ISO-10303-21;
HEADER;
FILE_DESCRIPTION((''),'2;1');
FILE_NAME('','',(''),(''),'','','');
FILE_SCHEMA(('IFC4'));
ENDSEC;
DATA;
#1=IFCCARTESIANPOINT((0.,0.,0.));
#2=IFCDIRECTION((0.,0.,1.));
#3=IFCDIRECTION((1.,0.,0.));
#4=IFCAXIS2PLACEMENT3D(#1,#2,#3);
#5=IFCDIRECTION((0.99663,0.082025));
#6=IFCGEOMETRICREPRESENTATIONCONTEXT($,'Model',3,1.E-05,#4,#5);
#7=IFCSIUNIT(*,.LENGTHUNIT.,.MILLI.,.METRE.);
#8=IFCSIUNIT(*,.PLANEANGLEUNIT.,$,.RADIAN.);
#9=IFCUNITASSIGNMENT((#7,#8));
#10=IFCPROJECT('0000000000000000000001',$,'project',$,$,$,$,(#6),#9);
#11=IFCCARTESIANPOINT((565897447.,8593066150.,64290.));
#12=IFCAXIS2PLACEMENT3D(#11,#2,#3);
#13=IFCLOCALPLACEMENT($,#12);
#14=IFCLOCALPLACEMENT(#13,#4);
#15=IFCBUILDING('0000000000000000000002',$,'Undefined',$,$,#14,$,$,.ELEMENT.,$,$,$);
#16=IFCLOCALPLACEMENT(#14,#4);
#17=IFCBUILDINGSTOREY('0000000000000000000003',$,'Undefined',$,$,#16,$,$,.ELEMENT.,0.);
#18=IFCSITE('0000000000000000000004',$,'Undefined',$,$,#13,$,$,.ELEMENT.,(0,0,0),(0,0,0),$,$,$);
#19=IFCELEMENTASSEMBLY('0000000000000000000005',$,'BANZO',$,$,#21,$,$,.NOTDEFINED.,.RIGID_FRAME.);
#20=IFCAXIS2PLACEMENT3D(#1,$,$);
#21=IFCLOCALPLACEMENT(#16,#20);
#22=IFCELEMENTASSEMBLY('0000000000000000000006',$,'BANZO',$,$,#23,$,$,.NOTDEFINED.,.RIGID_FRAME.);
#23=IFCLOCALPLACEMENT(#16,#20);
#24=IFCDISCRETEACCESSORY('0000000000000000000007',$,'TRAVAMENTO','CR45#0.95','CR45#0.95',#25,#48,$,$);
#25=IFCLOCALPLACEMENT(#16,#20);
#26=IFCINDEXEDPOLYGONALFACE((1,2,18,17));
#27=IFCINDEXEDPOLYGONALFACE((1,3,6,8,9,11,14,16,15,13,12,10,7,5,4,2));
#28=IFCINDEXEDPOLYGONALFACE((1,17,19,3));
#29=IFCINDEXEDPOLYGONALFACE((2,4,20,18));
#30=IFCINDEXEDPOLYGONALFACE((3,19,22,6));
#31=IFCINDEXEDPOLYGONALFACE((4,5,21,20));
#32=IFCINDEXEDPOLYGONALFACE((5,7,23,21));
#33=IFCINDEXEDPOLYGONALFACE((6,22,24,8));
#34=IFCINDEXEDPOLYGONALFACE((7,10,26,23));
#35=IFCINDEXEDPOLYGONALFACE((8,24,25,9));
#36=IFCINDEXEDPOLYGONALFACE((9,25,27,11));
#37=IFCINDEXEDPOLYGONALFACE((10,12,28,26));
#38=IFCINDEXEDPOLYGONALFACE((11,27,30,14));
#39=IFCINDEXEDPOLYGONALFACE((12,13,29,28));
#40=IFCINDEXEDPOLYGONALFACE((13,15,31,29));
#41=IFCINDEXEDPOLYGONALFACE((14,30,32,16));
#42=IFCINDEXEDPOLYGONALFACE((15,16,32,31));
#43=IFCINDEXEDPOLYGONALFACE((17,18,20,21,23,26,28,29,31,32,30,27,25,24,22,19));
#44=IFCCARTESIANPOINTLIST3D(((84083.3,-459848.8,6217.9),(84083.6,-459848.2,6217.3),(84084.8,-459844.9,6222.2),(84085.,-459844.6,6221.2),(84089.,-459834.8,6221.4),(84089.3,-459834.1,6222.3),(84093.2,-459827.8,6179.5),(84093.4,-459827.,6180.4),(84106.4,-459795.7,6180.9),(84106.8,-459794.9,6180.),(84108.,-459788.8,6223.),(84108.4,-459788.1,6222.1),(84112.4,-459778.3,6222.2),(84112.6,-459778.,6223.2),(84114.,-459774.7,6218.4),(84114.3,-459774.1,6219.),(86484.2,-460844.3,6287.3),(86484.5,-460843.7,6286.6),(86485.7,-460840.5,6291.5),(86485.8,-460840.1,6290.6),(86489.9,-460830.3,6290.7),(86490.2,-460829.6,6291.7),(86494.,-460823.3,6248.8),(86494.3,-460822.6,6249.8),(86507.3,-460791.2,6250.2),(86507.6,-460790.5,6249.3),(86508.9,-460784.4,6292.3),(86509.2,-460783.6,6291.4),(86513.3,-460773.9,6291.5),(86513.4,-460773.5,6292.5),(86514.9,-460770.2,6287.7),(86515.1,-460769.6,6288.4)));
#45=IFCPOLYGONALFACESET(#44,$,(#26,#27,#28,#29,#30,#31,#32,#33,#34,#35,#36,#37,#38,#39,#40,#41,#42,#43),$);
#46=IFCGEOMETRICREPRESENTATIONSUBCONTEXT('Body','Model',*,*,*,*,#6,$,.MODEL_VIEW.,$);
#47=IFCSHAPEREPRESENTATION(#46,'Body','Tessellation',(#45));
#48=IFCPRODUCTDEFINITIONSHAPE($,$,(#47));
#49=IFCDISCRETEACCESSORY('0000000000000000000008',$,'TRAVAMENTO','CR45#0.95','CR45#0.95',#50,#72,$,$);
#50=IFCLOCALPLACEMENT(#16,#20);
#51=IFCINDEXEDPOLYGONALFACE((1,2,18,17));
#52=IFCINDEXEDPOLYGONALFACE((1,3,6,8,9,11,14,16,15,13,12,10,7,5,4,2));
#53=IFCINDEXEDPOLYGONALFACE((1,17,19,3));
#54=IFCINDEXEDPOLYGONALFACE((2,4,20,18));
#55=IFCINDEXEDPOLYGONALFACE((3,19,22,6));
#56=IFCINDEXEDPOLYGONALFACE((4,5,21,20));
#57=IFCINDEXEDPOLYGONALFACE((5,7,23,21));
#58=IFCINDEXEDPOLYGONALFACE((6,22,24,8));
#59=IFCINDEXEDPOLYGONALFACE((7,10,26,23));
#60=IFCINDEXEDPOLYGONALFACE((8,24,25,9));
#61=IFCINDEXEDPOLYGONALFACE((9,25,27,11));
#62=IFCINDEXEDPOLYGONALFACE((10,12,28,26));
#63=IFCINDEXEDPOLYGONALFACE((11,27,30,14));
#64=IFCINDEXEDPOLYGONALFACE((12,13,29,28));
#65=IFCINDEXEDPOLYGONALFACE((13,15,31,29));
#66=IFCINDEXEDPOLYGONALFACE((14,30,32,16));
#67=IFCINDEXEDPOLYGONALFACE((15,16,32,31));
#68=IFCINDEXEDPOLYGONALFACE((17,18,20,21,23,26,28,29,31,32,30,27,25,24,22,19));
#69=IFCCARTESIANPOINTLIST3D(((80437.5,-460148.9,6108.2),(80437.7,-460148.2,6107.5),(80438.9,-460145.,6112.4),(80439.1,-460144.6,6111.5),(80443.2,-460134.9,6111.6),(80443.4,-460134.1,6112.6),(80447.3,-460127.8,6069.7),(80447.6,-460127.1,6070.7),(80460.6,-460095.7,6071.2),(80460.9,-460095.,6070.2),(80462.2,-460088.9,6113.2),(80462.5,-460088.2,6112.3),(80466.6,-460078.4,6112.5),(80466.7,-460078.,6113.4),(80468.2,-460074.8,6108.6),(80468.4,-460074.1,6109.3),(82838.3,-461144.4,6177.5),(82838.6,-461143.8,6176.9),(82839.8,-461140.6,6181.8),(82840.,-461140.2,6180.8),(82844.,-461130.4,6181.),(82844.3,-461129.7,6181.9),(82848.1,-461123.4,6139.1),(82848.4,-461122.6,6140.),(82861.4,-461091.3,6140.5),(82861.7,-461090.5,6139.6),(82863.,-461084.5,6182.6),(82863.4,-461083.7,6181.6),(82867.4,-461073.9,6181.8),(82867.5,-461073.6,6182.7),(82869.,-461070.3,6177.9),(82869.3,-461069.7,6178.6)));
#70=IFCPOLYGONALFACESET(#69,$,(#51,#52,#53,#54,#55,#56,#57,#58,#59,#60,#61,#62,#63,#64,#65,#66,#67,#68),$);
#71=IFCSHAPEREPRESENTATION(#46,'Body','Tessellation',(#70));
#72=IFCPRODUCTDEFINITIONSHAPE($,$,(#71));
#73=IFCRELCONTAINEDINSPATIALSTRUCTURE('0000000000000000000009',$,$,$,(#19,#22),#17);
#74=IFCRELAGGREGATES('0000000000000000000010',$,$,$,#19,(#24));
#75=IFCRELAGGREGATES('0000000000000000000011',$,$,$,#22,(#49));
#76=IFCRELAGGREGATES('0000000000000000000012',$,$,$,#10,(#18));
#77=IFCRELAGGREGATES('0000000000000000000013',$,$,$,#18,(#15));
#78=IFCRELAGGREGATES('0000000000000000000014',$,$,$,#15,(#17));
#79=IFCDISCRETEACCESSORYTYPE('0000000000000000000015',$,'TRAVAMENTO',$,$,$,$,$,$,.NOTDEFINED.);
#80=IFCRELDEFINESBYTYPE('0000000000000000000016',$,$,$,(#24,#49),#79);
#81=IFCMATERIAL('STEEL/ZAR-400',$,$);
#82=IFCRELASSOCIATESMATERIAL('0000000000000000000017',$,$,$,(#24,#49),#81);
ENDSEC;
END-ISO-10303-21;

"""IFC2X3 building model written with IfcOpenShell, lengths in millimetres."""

from ifc_helpers import new_model, si_unit, direction, frame, origin_with_axes, place, context, subcontext, project, spatial, polyline, outline, extrude, material, type_object, element, aggregate, save


model = new_model("IFC2X3")

# Units and contexts
model_context = context("Model", 3, precision=1e-05, world=origin_with_axes(), true_north=direction((0.99663, 0.082025)))
body_context = subcontext(model_context, "Body", "Model", "MODEL_VIEW")
ifc_project = project(units=[si_unit("LENGTHUNIT", "METRE", prefix="MILLI"), si_unit("PLANEANGLEUNIT", "RADIAN")], contexts=[model_context])

# Site, building, storey
site_placement = place(None, frame((565897447.0, 8593066150.0, 64290.0), z_axis=(0.0, 0.0, 1.0), x_axis=(1.0, 0.0, 0.0)))
site = spatial("IfcSite", under=ifc_project, at=site_placement, Name="Undefined", CompositionType="ELEMENT", RefLatitude=(0, 0, 0), RefLongitude=(0, 0, 0))
building_placement = place(site_placement, origin_with_axes())
building = spatial("IfcBuilding", under=site, at=building_placement, Name="Undefined", CompositionType="ELEMENT")
storey_placement = place(building_placement, origin_with_axes())
storey = spatial("IfcBuildingStorey", under=building, at=storey_placement, Name="Undefined", CompositionType="ELEMENT", Elevation=0.0)

# Element assembly
assembly_1_placement = place(storey_placement, origin_with_axes())
assembly_1 = element("IfcElementAssembly", 1, at=assembly_1_placement, inside=storey, Name="BANZO", AssemblyPlace="NOTDEFINED", PredefinedType="RIGID_FRAME")

# Element assembly
assembly_2_placement = place(storey_placement, origin_with_axes())
assembly_2 = element("IfcElementAssembly", 2, at=assembly_2_placement, inside=storey, Name="BANZO", AssemblyPlace="NOTDEFINED", PredefinedType="RIGID_FRAME")

# Discrete accessories
ifc_material_1 = material(Name="STEEL/ZAR-400")
discrete_accessory_type_1 = type_object("IfcDiscreteAccessoryType", Name="TRAVAMENTO")
discrete_accessory_1_placement = place(assembly_1_placement, frame((86500.3, -460806.6, 6270.5), z_axis=(0.029887, 0.002459, -0.99955), x_axis=(-0.923403, 0.382903, -0.026668)))
discrete_accessory_1 = element("IfcDiscreteAccessory", 3, at=discrete_accessory_1_placement, type_object=discrete_accessory_type_1, material=ifc_material_1, Name="TRAVAMENTO", Description="CR45#0.95", ObjectType="CR45#0.95", context=body_context, shape_type="SweptSolid", body=[
    extrude(outline(polyline([(-35.5, -20.5), (-24.9, -20.5), (-17.4, 21.5), (18.1, 21.5), (25.6, -20.5), (36.2, -20.5), (40.1, -16.6), (40.8, -17.3), (36.6, -21.5), (24.8, -21.5), (17.3, 20.5), (-16.6, 20.5), (-24.1, -21.5), (-35.9, -21.5), (-40.1, -17.3), (-39.4, -16.6), (-35.5, -20.5)])), frame((2600.0, 0.0, 0.0), z_axis=(-1.0, 0.0, 0.0), x_axis=(0.0, -1.0, 0.0)), (0.0, 0.0, 1.0), 2600.0),
])
aggregate(assembly_1, [discrete_accessory_1])
discrete_accessory_2_placement = place(assembly_2_placement, frame((82854.4, -461106.7, 6160.8), z_axis=(0.029887, 0.002459, -0.99955), x_axis=(-0.923403, 0.382903, -0.026668)))
discrete_accessory_2 = element("IfcDiscreteAccessory", 4, at=discrete_accessory_2_placement, type_object=discrete_accessory_type_1, material=ifc_material_1, Name="TRAVAMENTO", Description="CR45#0.95", ObjectType="CR45#0.95", context=body_context, shape_type="SweptSolid", body=[
    extrude(outline(polyline([(-35.5, -20.5), (-24.9, -20.5), (-17.4, 21.5), (18.1, 21.5), (25.6, -20.5), (36.2, -20.5), (40.1, -16.6), (40.8, -17.3), (36.6, -21.5), (24.8, -21.5), (17.3, 20.5), (-16.6, 20.5), (-24.1, -21.5), (-35.9, -21.5), (-40.1, -17.3), (-39.4, -16.6), (-35.5, -20.5)])), frame((2600.0, 0.0, 0.0), z_axis=(-1.0, 0.0, 0.0), x_axis=(0.0, -1.0, 0.0)), (0.0, 0.0, 1.0), 2600.0),
])
aggregate(assembly_2, [discrete_accessory_2])

save(model, "model.ifc")
